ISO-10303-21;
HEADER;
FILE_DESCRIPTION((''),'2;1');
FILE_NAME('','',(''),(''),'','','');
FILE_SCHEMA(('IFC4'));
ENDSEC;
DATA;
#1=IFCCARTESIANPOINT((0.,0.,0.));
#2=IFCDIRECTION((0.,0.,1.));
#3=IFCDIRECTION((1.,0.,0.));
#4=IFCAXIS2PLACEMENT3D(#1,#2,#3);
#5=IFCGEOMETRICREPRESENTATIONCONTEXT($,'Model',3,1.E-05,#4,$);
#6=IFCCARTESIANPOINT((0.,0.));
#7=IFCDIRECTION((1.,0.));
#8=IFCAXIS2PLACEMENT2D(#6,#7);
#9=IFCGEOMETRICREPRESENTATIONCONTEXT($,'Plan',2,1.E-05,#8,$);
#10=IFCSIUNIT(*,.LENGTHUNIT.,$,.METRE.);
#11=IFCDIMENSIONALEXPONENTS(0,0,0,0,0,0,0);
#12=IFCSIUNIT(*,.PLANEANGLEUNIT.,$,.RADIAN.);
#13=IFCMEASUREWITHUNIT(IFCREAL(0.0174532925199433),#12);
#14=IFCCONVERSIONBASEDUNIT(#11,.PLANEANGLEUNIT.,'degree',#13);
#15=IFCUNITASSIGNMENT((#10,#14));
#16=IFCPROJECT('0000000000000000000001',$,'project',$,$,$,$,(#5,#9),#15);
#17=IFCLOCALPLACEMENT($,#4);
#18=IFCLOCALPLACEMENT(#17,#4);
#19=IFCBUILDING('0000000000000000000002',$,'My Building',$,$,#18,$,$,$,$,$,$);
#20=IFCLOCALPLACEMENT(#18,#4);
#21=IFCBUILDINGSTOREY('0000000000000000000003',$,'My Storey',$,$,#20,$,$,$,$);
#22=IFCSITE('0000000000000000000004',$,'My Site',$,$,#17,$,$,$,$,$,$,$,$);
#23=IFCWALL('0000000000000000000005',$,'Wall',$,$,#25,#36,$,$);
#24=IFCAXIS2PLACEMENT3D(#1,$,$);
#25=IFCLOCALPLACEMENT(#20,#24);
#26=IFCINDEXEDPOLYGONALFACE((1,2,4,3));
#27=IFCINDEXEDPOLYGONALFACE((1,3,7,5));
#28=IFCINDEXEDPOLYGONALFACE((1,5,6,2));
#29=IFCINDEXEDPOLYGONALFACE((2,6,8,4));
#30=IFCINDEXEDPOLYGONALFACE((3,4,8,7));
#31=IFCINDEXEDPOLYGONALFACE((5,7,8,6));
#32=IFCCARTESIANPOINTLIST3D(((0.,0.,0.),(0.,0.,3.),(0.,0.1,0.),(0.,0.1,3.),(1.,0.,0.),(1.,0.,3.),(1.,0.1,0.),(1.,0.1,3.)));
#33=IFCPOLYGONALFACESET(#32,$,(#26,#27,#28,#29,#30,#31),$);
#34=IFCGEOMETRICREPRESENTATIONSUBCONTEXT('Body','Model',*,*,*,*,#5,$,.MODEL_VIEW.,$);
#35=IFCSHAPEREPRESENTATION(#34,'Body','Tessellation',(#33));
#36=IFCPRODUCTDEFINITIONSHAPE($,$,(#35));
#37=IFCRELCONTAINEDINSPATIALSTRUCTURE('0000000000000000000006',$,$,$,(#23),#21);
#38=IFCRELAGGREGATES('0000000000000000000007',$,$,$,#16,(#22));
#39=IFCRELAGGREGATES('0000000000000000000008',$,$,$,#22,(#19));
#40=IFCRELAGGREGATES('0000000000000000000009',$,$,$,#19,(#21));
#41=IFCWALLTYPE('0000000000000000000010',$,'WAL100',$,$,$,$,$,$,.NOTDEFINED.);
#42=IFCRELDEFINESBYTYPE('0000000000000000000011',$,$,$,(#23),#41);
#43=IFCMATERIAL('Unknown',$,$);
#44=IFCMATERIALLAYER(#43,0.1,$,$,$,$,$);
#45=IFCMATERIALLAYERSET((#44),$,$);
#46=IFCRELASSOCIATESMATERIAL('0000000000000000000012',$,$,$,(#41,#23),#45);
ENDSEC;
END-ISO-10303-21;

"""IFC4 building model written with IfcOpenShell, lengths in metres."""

from ifc_helpers import new_model, entity, si_unit, converted_unit, origin_with_axes, origin_2d_with_axis, place, context, subcontext, project, spatial, indexed_curve, outline, extrude, material, layer, layer_set, layer_usage, type_object, element, save


model = new_model("IFC4")

# Units and contexts
model_context = context("Model", 3, precision=1e-05, world=origin_with_axes())
plan_context = context("Plan", 2, precision=1e-05, world=origin_2d_with_axis())
body_context = subcontext(model_context, "Body", "Model", "MODEL_VIEW")
ifc_project = project(units=[si_unit("LENGTHUNIT", "METRE"), converted_unit("PLANEANGLEUNIT", "degree", entity("IfcReal", 0.0174532925199433), si_unit("PLANEANGLEUNIT", "RADIAN"), dimensions=[0, 0, 0, 0, 0, 0, 0])], contexts=[model_context, plan_context])

# Site, building, storey
site_placement = place(None, origin_with_axes())
site = spatial("IfcSite", under=ifc_project, at=site_placement, Name="My Site")
building_placement = place(site_placement, origin_with_axes())
building = spatial("IfcBuilding", under=site, at=building_placement, Name="My Building")
storey_placement = place(building_placement, origin_with_axes())
storey = spatial("IfcBuildingStorey", under=building, at=storey_placement, Name="My Storey")

# Wall
ifc_material = material(Name="Unknown")
ifc_layer = layer(ifc_material, 0.1)
ifc_layer_set = layer_set([ifc_layer])
ifc_layer_usage = layer_usage(ifc_layer_set, "AXIS2", "POSITIVE", 0.0)
wall_type = type_object("IfcWallType", Name="WAL100", PredefinedType="NOTDEFINED", material=ifc_layer_set)
wall_placement = place(storey_placement, origin_with_axes())
element("IfcWall", 1, at=wall_placement, inside=storey, type_object=wall_type, material=ifc_layer_usage, Name="Wall", context=body_context, shape_type="SweptSolid", body=[
    extrude(outline(indexed_curve([(0.0, 0.0), (0.0, 0.1), (1.0, 0.1), (1.0, 0.0), (0.0, 0.0)], self_intersect=False)), origin_with_axes(), (0.0, 0.0, 1.0), 3.0),
])

save(model, "model.ifc")
